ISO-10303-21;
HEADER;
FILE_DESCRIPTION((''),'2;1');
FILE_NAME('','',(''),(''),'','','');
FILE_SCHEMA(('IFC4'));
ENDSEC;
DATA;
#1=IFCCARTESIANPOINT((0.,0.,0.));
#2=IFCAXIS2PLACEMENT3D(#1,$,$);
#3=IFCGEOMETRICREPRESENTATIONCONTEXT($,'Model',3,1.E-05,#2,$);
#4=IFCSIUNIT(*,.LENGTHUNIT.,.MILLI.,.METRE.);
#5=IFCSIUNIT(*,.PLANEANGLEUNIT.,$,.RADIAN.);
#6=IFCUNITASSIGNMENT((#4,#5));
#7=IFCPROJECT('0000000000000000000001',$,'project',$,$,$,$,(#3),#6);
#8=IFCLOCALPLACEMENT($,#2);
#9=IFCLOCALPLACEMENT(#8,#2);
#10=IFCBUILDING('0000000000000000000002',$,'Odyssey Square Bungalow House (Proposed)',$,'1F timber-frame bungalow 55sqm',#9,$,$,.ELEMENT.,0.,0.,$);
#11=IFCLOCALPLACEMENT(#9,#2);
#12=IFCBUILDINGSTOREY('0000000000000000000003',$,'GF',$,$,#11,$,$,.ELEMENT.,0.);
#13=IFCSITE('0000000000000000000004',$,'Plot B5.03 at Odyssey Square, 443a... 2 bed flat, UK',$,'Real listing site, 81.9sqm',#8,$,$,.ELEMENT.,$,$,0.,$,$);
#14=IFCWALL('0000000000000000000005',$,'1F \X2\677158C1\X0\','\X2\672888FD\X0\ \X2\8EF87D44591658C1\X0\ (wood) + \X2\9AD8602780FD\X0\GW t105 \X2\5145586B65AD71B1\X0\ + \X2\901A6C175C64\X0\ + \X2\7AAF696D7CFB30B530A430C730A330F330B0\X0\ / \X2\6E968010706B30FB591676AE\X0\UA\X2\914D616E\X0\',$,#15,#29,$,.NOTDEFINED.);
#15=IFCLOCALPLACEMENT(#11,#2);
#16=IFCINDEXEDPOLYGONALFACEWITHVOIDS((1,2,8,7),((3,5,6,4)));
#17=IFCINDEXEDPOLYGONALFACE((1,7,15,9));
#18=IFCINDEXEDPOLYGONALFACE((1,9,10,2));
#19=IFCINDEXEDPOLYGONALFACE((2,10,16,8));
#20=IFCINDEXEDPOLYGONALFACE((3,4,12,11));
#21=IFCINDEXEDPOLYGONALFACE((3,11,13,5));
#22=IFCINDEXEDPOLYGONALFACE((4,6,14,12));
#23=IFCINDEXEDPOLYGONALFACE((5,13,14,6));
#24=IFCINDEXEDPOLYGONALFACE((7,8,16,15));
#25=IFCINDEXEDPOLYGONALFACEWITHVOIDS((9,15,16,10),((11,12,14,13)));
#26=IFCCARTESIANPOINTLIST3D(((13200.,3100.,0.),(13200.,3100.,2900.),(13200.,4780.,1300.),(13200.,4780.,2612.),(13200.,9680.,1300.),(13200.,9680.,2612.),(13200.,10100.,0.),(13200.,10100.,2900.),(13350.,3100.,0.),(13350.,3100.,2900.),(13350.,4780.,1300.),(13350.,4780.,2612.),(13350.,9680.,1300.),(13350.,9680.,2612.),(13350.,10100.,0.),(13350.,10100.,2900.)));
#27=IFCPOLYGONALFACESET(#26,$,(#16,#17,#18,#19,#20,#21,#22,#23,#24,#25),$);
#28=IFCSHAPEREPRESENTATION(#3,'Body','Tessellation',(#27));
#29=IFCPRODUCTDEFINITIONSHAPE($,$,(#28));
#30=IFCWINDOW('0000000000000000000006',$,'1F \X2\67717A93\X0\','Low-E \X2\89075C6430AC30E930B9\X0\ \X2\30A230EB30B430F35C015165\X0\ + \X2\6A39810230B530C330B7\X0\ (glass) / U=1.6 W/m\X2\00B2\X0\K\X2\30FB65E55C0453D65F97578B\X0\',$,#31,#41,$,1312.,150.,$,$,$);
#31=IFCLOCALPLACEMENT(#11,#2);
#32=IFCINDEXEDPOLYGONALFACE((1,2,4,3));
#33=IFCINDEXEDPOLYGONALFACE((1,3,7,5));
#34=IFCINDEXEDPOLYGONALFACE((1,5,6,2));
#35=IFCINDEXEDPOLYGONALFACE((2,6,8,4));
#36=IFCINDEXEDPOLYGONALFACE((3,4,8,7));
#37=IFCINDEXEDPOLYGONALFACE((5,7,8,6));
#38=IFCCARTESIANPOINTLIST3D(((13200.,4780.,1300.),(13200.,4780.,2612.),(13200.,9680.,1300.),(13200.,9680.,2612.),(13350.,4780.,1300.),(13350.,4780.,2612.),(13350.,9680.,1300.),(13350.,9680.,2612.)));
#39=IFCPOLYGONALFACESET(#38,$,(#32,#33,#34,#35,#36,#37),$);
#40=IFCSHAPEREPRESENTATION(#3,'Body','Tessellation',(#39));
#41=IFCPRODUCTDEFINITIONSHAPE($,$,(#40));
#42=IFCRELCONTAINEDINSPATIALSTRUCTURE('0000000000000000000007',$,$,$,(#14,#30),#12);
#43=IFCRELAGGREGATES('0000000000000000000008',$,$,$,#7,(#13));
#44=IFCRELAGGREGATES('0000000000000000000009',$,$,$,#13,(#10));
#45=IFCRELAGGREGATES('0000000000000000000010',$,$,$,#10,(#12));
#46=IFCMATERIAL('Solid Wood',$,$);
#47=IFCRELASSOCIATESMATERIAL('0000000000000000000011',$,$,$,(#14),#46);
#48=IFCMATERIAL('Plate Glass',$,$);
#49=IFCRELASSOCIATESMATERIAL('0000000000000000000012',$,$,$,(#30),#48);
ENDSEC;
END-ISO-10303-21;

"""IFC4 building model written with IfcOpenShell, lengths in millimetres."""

from ifc_helpers import new_model, si_unit, frame, frame_2d, origin, place, context, project, spatial, rectangle, extrude, material, element, fill, save


model = new_model("IFC4")

# Units and contexts
model_context = context("Model", 3, precision=1e-05, world=origin())
ifc_project = project(units=[si_unit("LENGTHUNIT", "METRE", prefix="MILLI"), si_unit("PLANEANGLEUNIT", "RADIAN")], contexts=[model_context])

# Site, building, storey
site_placement = place(None, origin())
site = spatial("IfcSite", under=ifc_project, at=site_placement, Name="Plot B5.03 at Odyssey Square, 443a... 2 bed flat, UK", ObjectType="Real listing site, 81.9sqm", CompositionType="ELEMENT", RefElevation=0.0)
building_placement = place(site_placement, origin())
building = spatial("IfcBuilding", under=site, at=building_placement, Name="Odyssey Square Bungalow House (Proposed)", ObjectType="1F timber-frame bungalow 55sqm", CompositionType="ELEMENT", ElevationOfRefHeight=0.0, ElevationOfTerrain=0.0)
storey_placement = place(building_placement, origin())
storey = spatial("IfcBuildingStorey", under=building, at=storey_placement, Name="GF", CompositionType="ELEMENT", Elevation=0.0)

# Shared definitions
ifc_material_1 = material(Name="Solid Wood")

# Shared definitions
ifc_material_2 = material(Name="Plate Glass")

# Wall, opening, window
wall_1_placement = place(storey_placement, frame((6600.0, 1550.0, 0.0)))
wall_1 = element("IfcWall", 1, at=wall_1_placement, inside=storey, material=ifc_material_1, Name="1F 東壁", Description="木製 軸組外壁 (wood) + 高性能GW t105 充填断熱 + 通気層 + 窯業系サイディング / 準耐火・外皮UA配慮", PredefinedType="NOTDEFINED", context=model_context, shape_type="SweptSolid", body=[
    extrude(rectangle(XDim=150.0, YDim=7000.0, at=frame_2d((75.0, 3500.0))), frame((6600.0, 1550.0, 0.0)), (0.0, 0.0, 1.0), 2900.0),
])
opening_1_placement = place(storey_placement, frame((6600.0, 2390.0, 650.0)))
opening_1 = element("IfcOpeningElement", 2, at=opening_1_placement, cuts=wall_1, PredefinedType="NOTDEFINED", context=model_context, shape_type="SweptSolid", body=[
    extrude(rectangle(XDim=150.0, YDim=4900.0, at=frame_2d((75.0, 2450.0))), frame((6600.0, 2390.0, 650.0)), (0.0, 0.0, 1.0), 1312.0),
])
window_1_placement = place(storey_placement, frame((6600.0, 2390.0, 650.0)))
window_1 = element("IfcWindow", 3, at=window_1_placement, inside=storey, material=ifc_material_2, Name="1F 東窓", Description="Low-E 複層ガラス アルゴン封入 + 樹脂サッシ (glass) / U=1.6 W/m²K・日射取得型", OverallHeight=1312.0, OverallWidth=150.0, context=model_context, shape_type="SweptSolid", body=[
    extrude(rectangle(XDim=150.0, YDim=4900.0, at=frame_2d((75.0, 2450.0))), frame((6600.0, 2390.0, 650.0)), (0.0, 0.0, 1.0), 1312.0),
])
fill(opening_1, window_1)

save(model, "model.ifc")
